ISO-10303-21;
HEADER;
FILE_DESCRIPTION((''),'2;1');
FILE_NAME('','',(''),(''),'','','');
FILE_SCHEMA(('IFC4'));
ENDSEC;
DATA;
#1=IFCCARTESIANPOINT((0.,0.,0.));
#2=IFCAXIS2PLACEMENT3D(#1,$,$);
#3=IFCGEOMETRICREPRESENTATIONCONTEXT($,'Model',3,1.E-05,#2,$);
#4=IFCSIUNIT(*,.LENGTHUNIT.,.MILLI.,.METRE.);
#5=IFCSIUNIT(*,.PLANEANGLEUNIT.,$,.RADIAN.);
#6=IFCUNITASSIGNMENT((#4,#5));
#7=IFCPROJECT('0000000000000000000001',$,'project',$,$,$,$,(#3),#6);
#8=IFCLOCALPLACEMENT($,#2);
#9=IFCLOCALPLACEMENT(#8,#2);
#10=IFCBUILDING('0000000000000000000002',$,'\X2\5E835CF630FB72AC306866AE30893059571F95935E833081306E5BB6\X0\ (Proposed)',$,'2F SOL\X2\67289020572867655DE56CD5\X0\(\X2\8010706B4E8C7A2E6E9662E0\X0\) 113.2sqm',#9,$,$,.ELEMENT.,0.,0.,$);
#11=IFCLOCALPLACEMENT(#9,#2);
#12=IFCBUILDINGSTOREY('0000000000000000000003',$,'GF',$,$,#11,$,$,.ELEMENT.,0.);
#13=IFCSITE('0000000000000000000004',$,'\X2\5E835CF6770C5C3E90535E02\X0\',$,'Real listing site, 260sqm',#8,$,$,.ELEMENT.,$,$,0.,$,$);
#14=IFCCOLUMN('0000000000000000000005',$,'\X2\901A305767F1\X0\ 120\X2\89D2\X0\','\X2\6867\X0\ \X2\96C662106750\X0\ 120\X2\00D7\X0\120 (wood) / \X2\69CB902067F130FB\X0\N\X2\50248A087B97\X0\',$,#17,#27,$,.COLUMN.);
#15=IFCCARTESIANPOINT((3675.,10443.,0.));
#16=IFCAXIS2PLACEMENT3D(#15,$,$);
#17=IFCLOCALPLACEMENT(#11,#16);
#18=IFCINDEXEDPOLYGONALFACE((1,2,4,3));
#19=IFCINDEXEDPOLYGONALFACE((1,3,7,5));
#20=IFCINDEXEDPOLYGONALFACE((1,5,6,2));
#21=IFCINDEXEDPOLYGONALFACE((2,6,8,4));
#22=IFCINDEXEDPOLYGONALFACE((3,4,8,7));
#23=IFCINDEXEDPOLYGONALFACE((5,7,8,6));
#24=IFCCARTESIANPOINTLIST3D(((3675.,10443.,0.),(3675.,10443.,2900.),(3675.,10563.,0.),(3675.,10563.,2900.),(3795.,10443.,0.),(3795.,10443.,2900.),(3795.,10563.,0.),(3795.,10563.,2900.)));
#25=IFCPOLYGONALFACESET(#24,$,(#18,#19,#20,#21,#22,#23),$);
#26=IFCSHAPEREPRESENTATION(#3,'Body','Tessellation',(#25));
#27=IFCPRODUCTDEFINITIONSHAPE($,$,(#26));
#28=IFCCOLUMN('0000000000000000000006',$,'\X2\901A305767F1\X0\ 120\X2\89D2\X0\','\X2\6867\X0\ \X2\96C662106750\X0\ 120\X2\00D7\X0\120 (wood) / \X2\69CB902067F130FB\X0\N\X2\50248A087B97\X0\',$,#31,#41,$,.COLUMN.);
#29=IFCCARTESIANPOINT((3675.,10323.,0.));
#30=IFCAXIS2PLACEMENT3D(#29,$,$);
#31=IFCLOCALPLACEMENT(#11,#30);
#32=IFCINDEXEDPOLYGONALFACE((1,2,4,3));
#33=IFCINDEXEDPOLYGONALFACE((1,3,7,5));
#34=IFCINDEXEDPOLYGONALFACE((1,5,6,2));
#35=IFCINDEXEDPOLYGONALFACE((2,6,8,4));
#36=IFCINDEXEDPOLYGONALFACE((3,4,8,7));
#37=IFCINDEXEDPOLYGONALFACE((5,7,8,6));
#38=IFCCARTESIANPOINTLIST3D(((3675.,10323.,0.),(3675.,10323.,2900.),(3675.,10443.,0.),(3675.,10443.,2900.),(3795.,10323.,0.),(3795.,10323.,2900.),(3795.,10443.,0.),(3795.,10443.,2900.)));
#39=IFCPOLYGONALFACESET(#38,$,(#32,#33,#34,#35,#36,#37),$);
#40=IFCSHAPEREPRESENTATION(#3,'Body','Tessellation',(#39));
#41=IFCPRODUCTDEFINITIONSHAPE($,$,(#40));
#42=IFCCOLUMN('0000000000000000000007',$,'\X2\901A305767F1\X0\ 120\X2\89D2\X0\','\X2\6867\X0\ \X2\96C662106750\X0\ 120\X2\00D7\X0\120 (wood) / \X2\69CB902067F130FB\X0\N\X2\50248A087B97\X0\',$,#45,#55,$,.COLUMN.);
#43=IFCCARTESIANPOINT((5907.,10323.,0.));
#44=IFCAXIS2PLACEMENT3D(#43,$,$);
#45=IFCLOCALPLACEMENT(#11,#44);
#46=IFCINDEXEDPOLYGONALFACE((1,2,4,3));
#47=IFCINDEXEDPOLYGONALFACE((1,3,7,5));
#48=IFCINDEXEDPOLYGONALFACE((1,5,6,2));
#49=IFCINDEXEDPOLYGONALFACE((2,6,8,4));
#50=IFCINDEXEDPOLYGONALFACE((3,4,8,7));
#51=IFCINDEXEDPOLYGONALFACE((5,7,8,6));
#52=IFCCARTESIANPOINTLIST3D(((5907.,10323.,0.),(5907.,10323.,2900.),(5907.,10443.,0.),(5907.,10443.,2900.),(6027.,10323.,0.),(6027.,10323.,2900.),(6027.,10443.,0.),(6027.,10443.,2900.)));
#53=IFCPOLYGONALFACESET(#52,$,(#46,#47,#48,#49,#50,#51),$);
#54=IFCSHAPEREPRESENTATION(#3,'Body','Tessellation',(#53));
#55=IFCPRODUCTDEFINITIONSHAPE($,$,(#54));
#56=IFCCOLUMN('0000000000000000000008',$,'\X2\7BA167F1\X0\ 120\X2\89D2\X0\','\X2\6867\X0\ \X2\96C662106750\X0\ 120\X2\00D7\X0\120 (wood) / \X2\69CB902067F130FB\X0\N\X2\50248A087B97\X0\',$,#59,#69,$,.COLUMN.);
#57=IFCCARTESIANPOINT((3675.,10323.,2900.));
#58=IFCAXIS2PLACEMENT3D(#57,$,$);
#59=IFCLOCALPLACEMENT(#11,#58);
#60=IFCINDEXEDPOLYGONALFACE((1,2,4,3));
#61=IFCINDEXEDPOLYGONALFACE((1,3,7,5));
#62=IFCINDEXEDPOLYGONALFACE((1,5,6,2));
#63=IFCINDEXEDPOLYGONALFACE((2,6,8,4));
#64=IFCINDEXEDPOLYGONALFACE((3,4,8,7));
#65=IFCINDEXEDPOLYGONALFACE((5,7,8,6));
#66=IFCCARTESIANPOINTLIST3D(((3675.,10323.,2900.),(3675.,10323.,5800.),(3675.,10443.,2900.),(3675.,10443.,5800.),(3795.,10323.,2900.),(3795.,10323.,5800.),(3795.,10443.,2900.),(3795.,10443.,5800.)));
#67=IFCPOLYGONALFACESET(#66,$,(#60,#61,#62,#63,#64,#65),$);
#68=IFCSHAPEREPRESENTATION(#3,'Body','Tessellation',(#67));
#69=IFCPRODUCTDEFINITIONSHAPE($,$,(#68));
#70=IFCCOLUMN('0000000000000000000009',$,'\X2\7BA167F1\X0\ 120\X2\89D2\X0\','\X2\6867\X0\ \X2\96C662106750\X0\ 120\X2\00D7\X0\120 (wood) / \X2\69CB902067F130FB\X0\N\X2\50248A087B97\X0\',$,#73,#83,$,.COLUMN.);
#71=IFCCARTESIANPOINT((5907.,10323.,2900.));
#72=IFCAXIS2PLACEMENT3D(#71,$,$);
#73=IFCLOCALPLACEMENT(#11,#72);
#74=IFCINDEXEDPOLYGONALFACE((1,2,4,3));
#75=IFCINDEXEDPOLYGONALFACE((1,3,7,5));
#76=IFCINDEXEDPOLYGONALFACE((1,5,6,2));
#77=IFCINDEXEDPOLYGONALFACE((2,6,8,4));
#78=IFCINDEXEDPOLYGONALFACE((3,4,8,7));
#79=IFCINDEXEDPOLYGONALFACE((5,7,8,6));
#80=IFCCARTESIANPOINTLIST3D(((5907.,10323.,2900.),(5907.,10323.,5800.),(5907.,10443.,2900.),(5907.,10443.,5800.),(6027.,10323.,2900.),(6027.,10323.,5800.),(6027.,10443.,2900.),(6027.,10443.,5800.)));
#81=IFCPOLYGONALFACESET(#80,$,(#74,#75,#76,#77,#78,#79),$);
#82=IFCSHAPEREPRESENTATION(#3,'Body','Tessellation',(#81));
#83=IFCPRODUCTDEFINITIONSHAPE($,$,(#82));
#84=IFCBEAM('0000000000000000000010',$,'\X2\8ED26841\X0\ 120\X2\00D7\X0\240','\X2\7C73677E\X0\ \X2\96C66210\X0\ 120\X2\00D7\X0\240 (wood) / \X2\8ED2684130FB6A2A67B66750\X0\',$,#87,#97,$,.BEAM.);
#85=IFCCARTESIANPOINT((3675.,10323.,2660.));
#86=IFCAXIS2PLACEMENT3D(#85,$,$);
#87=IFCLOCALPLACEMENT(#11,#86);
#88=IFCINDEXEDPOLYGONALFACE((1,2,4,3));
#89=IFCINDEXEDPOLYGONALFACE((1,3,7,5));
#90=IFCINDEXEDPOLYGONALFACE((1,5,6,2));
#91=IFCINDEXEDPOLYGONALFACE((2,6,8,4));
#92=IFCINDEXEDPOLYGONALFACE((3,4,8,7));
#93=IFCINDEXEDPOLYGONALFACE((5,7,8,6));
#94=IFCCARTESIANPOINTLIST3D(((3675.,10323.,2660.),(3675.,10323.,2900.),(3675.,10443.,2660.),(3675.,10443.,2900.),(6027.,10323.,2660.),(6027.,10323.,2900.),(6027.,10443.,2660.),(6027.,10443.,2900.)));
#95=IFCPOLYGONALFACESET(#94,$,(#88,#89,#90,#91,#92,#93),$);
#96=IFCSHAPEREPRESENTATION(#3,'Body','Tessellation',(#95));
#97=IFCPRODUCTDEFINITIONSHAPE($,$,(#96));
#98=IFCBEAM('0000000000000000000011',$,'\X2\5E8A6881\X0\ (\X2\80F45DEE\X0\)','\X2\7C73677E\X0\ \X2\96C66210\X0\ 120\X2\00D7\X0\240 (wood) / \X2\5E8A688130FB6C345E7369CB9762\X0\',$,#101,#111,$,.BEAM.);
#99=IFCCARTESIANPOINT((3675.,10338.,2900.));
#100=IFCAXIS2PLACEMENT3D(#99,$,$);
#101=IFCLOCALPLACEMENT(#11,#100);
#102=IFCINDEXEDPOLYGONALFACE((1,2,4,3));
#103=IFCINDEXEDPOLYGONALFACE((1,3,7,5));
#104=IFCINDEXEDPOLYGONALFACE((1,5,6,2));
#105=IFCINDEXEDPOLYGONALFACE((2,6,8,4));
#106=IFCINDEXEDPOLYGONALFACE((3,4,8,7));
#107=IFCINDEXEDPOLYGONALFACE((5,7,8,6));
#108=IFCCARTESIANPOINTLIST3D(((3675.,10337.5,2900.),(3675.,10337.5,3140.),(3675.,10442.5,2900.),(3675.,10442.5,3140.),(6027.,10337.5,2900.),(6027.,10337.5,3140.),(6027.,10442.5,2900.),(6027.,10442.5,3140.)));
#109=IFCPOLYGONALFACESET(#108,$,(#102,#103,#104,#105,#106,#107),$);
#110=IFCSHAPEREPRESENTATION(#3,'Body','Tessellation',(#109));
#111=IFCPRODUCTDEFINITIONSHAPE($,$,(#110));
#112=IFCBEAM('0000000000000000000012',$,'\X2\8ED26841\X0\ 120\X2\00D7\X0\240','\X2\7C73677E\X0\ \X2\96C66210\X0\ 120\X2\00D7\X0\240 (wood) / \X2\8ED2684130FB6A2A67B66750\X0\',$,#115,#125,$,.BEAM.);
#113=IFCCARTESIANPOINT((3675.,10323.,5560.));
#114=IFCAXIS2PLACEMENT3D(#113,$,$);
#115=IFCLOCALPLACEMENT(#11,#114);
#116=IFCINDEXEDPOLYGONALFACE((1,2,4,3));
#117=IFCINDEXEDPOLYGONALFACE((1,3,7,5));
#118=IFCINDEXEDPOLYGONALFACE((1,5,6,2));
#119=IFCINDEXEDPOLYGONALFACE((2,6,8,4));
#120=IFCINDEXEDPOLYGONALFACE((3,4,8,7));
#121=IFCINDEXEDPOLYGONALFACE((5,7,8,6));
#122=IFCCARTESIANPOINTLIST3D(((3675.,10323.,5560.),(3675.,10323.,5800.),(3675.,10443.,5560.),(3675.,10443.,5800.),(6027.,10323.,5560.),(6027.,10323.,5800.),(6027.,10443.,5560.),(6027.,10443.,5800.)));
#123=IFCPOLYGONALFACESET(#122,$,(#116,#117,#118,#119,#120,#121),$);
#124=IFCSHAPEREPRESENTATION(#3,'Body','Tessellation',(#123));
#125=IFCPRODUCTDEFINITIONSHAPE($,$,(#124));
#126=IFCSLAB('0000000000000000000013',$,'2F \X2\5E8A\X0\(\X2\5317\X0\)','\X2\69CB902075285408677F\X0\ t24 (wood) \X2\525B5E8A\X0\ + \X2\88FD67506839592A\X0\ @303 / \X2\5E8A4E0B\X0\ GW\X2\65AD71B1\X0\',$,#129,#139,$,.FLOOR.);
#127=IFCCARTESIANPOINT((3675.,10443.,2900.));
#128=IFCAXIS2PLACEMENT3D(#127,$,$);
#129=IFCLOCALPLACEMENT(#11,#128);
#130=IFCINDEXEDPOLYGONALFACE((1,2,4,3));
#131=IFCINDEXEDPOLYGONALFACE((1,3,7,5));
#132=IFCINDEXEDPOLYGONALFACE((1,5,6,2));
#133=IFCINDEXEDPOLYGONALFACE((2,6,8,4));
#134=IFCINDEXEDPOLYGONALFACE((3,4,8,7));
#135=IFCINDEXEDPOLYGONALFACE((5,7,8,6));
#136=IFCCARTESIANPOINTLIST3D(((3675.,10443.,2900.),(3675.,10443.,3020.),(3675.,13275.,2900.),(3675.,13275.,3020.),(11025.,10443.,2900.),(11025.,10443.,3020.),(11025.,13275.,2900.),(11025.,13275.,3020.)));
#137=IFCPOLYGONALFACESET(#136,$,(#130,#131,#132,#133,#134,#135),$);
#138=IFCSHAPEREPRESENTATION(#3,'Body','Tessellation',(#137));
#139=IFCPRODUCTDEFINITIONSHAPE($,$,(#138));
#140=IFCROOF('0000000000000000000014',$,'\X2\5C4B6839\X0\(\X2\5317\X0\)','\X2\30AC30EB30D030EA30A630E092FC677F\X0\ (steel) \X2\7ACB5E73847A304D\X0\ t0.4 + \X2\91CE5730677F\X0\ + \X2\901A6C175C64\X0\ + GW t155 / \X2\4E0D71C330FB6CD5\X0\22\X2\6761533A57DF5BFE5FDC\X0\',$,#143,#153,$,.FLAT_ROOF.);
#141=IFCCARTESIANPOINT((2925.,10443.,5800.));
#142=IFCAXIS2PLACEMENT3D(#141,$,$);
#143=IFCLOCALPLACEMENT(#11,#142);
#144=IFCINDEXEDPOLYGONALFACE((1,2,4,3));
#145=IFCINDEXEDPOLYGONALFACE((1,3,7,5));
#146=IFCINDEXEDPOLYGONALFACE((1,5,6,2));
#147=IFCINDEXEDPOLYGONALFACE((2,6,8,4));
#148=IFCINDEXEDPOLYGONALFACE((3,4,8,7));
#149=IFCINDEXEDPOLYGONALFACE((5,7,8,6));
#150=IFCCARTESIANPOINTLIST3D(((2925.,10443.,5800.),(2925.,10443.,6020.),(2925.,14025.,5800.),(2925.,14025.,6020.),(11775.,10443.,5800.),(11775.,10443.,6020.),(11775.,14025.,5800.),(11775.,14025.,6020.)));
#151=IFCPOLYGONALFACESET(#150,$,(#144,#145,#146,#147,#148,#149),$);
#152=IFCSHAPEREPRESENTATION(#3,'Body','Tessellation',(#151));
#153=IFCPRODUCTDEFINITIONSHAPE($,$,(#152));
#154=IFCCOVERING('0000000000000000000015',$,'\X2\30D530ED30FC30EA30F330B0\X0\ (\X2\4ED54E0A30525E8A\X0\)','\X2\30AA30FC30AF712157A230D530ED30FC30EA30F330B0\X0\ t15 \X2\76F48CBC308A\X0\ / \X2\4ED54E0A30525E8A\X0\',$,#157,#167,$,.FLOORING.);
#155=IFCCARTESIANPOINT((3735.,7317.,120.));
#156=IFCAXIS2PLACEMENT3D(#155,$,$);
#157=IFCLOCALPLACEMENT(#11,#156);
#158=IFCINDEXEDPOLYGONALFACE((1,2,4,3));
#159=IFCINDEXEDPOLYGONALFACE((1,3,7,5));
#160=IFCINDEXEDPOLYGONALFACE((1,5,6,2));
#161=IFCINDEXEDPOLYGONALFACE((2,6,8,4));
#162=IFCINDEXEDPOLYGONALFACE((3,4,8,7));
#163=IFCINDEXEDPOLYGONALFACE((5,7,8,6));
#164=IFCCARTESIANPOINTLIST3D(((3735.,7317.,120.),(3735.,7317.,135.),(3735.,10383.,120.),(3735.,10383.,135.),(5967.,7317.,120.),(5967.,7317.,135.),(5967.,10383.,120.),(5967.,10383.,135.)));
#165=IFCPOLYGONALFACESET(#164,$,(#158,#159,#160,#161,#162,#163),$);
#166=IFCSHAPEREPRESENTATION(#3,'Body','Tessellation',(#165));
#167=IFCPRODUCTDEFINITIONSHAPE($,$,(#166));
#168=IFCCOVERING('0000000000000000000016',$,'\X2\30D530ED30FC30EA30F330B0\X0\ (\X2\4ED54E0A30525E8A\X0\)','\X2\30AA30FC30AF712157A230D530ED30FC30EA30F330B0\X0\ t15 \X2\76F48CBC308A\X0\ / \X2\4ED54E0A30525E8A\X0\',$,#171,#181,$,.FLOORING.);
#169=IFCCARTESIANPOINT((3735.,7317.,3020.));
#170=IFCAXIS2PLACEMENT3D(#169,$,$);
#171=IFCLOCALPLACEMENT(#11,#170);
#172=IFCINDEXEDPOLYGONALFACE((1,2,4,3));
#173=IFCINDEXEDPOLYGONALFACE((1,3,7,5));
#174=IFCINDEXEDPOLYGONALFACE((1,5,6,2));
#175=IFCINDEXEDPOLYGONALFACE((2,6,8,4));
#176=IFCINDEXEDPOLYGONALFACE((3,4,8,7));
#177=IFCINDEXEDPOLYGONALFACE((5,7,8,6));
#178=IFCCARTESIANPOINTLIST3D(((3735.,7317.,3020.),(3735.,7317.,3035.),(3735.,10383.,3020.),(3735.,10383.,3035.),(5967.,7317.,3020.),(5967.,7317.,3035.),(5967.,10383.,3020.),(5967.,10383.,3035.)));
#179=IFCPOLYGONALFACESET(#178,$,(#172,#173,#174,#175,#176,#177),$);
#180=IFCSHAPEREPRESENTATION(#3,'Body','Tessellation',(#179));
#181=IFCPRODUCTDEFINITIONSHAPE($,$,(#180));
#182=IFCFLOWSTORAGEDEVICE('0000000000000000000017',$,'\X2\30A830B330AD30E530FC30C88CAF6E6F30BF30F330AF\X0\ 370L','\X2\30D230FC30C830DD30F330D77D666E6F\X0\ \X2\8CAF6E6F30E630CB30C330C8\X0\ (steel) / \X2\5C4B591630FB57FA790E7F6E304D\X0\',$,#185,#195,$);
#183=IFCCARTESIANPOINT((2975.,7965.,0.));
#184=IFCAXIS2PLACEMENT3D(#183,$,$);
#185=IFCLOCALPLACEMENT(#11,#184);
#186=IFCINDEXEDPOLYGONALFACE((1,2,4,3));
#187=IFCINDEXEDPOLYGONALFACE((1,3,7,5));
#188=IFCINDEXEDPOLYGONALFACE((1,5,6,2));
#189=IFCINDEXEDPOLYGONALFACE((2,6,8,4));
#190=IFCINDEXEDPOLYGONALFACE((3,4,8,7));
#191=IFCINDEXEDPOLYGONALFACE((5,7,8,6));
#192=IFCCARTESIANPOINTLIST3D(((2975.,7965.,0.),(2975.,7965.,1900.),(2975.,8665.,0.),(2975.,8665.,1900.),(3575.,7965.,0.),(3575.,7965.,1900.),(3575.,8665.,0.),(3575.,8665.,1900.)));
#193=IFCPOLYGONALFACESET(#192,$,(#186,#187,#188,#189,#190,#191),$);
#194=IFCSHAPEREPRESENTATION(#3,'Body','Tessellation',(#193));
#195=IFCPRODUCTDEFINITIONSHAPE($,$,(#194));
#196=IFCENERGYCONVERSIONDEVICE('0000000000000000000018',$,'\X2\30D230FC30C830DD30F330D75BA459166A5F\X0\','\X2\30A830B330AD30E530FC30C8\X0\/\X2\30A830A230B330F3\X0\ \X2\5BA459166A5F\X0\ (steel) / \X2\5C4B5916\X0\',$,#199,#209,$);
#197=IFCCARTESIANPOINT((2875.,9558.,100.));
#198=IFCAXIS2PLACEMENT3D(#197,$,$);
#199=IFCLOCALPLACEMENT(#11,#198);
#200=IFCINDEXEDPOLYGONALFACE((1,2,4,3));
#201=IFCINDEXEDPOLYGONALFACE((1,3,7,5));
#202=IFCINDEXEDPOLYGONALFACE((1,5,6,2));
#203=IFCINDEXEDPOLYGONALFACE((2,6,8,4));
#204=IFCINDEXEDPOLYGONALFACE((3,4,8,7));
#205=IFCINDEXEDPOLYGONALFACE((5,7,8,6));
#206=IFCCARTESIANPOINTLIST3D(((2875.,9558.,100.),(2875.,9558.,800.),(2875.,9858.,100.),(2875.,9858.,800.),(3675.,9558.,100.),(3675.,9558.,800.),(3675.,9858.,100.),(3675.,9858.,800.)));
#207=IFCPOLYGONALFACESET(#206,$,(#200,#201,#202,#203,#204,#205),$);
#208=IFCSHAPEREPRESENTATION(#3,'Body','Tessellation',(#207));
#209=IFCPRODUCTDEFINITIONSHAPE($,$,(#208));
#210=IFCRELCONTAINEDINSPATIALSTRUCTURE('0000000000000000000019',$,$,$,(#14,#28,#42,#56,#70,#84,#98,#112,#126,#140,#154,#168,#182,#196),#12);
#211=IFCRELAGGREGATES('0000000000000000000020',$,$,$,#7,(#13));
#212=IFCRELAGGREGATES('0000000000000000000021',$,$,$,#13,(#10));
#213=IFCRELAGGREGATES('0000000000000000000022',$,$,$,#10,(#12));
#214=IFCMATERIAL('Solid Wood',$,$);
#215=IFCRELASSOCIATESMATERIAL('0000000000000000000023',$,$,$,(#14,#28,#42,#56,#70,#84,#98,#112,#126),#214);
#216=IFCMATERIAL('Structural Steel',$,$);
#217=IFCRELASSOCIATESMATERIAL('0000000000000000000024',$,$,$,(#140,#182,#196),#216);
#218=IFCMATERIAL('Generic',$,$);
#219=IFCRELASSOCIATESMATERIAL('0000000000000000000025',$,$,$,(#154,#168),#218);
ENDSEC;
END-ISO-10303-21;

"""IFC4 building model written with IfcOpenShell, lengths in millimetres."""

from ifc_helpers import new_model, si_unit, frame, frame_2d, origin, place, context, project, spatial, rectangle, extrude, material, element, save


model = new_model("IFC4")

# Units and contexts
model_context = context("Model", 3, precision=1e-05, world=origin())
ifc_project = project(units=[si_unit("LENGTHUNIT", "METRE", prefix="MILLI"), si_unit("PLANEANGLEUNIT", "RADIAN")], contexts=[model_context])

# Site, building, storey
site_placement = place(None, origin())
site = spatial("IfcSite", under=ifc_project, at=site_placement, Name="広島県尾道市", ObjectType="Real listing site, 260sqm", CompositionType="ELEMENT", RefElevation=0.0)
building_placement = place(site_placement, origin())
building = spatial("IfcBuilding", under=site, at=building_placement, Name="広島・犬と暮らす土間広めの家 (Proposed)", ObjectType="2F SOL木造在来工法(耐火二種準拠) 113.2sqm", CompositionType="ELEMENT", ElevationOfRefHeight=0.0, ElevationOfTerrain=0.0)
storey_placement = place(building_placement, origin())
storey = spatial("IfcBuildingStorey", under=building, at=storey_placement, Name="GF", CompositionType="ELEMENT", Elevation=0.0)

# Columns
ifc_material_1 = material(Name="Solid Wood")
column_1_placement = place(storey_placement, frame((3675.0, 10443.0, 0.0)))
element("IfcColumn", 1, at=column_1_placement, inside=storey, material=ifc_material_1, Name="通し柱 120角", Description="桧 集成材 120×120 (wood) / 構造柱・N値計算", PredefinedType="COLUMN", context=model_context, shape_type="SweptSolid", body=[
    extrude(rectangle(XDim=120.0, YDim=120.0, at=frame_2d((60.0, 60.0))), frame((3675.0, 10443.0, 0.0)), (0.0, 0.0, 1.0), 2900.0),
])
column_2_placement = place(storey_placement, frame((3675.0, 10323.0, 0.0)))
element("IfcColumn", 2, at=column_2_placement, inside=storey, material=ifc_material_1, Name="通し柱 120角", Description="桧 集成材 120×120 (wood) / 構造柱・N値計算", PredefinedType="COLUMN", context=model_context, shape_type="SweptSolid", body=[
    extrude(rectangle(XDim=120.0, YDim=120.0, at=frame_2d((60.0, 60.0))), frame((3675.0, 10323.0, 0.0)), (0.0, 0.0, 1.0), 2900.0),
])
column_3_placement = place(storey_placement, frame((5907.0, 10323.0, 0.0)))
element("IfcColumn", 3, at=column_3_placement, inside=storey, material=ifc_material_1, Name="通し柱 120角", Description="桧 集成材 120×120 (wood) / 構造柱・N値計算", PredefinedType="COLUMN", context=model_context, shape_type="SweptSolid", body=[
    extrude(rectangle(XDim=120.0, YDim=120.0, at=frame_2d((60.0, 60.0))), frame((5907.0, 10323.0, 0.0)), (0.0, 0.0, 1.0), 2900.0),
])
column_4_placement = place(storey_placement, frame((3675.0, 10323.0, 2900.0)))
element("IfcColumn", 4, at=column_4_placement, inside=storey, material=ifc_material_1, Name="管柱 120角", Description="桧 集成材 120×120 (wood) / 構造柱・N値計算", PredefinedType="COLUMN", context=model_context, shape_type="SweptSolid", body=[
    extrude(rectangle(XDim=120.0, YDim=120.0, at=frame_2d((60.0, 60.0))), frame((3675.0, 10323.0, 2900.0)), (0.0, 0.0, 1.0), 2900.0),
])
column_5_placement = place(storey_placement, frame((5907.0, 10323.0, 2900.0)))
element("IfcColumn", 5, at=column_5_placement, inside=storey, material=ifc_material_1, Name="管柱 120角", Description="桧 集成材 120×120 (wood) / 構造柱・N値計算", PredefinedType="COLUMN", context=model_context, shape_type="SweptSolid", body=[
    extrude(rectangle(XDim=120.0, YDim=120.0, at=frame_2d((60.0, 60.0))), frame((5907.0, 10323.0, 2900.0)), (0.0, 0.0, 1.0), 2900.0),
])

# Beams
beam_1_placement = place(storey_placement, frame((3675.0, 10323.0, 2660.0)))
element("IfcBeam", 6, at=beam_1_placement, inside=storey, material=ifc_material_1, Name="軒桁 120×240", Description="米松 集成 120×240 (wood) / 軒桁・横架材", PredefinedType="BEAM", context=model_context, shape_type="SweptSolid", body=[
    extrude(rectangle(XDim=2352.0, YDim=120.0, at=frame_2d((1176.0, 60.0))), frame((3675.0, 10323.0, 2660.0)), (0.0, 0.0, 1.0), 240.0),
])
beam_2_placement = place(storey_placement, frame((3675.0, 10338.0, 2900.0)))
element("IfcBeam", 7, at=beam_2_placement, inside=storey, material=ifc_material_1, Name="床梁 (胴差)", Description="米松 集成 120×240 (wood) / 床梁・水平構面", PredefinedType="BEAM", context=model_context, shape_type="SweptSolid", body=[
    extrude(rectangle(XDim=2352.0, YDim=105.0, at=frame_2d((1176.0, 52.0))), frame((3675.0, 10338.0, 2900.0)), (0.0, 0.0, 1.0), 240.0),
])
beam_3_placement = place(storey_placement, frame((3675.0, 10323.0, 5560.0)))
element("IfcBeam", 8, at=beam_3_placement, inside=storey, material=ifc_material_1, Name="軒桁 120×240", Description="米松 集成 120×240 (wood) / 軒桁・横架材", PredefinedType="BEAM", context=model_context, shape_type="SweptSolid", body=[
    extrude(rectangle(XDim=2352.0, YDim=120.0, at=frame_2d((1176.0, 60.0))), frame((3675.0, 10323.0, 5560.0)), (0.0, 0.0, 1.0), 240.0),
])

# Slab
slab_1_placement = place(storey_placement, frame((3675.0, 10443.0, 2900.0)))
element("IfcSlab", 9, at=slab_1_placement, inside=storey, material=ifc_material_1, Name="2F 床(北)", Description="構造用合板 t24 (wood) 剛床 + 製材根太 @303 / 床下 GW断熱", PredefinedType="FLOOR", context=model_context, shape_type="SweptSolid", body=[
    extrude(rectangle(XDim=7350.0, YDim=2832.0, at=frame_2d((3675.0, 1416.0))), frame((3675.0, 10443.0, 2900.0)), (0.0, 0.0, 1.0), 120.0),
])

# Roof
ifc_material_2 = material(Name="Structural Steel")
for number, where, name in (
    (10, (2925.0, 10443.0, 5800.0), "屋根(北)"),
):
    element("IfcRoof", number, at=place(storey_placement, frame(where)), inside=storey, material=ifc_material_2, Name=name, Description="ガルバリウム鋼板 (steel) 立平葺き t0.4 + 野地板 + 通気層 + GW t155 / 不燃・法22条区域対応", PredefinedType="FLAT_ROOF", context=model_context, shape_type="SweptSolid", body=[
        extrude(rectangle(XDim=8850.0, YDim=3582.0, at=frame_2d((4425.0, 1791.0))), frame((2925.0, 10443.0, 5800.0)), (0.0, 0.0, 1.0), 220.0),
    ])

# Coverings
ifc_material_3 = material(Name="Generic")
covering_1_placement = place(storey_placement, frame((3735.0, 7317.0, 120.0)))
element("IfcCovering", 11, at=covering_1_placement, inside=storey, material=ifc_material_3, Name="フローリング (仕上げ床)", Description="オーク無垢フローリング t15 直貼り / 仕上げ床", PredefinedType="FLOORING", context=model_context, shape_type="SweptSolid", body=[
    extrude(rectangle(XDim=2232.0, YDim=3066.0, at=frame_2d((1116.0, 1533.0))), frame((3735.0, 7317.0, 120.0)), (0.0, 0.0, 1.0), 15.0),
])
covering_2_placement = place(storey_placement, frame((3735.0, 7317.0, 3020.0)))
element("IfcCovering", 12, at=covering_2_placement, inside=storey, material=ifc_material_3, Name="フローリング (仕上げ床)", Description="オーク無垢フローリング t15 直貼り / 仕上げ床", PredefinedType="FLOORING", context=model_context, shape_type="SweptSolid", body=[
    extrude(rectangle(XDim=2232.0, YDim=3066.0, at=frame_2d((1116.0, 1533.0))), frame((3735.0, 7317.0, 3020.0)), (0.0, 0.0, 1.0), 15.0),
])

# Flow storage device
flow_storage_device_placement = place(storey_placement, frame((2975.0, 7965.0, 0.0)))
element("IfcFlowStorageDevice", 13, at=flow_storage_device_placement, inside=storey, material=ifc_material_2, Name="エコキュート貯湯タンク 370L", Description="ヒートポンプ給湯 貯湯ユニット (steel) / 屋外・基礎置き", context=model_context, shape_type="SweptSolid", body=[
    extrude(rectangle(XDim=600.0, YDim=700.0, at=frame_2d((300.0, 350.0))), frame((2975.0, 7965.0, 0.0)), (0.0, 0.0, 1.0), 1900.0),
])

# Energy conversion device
energy_conversion_device_placement = place(storey_placement, frame((2875.0, 9558.0, 100.0)))
element("IfcEnergyConversionDevice", 14, at=energy_conversion_device_placement, inside=storey, material=ifc_material_2, Name="ヒートポンプ室外機", Description="エコキュート/エアコン 室外機 (steel) / 屋外", context=model_context, shape_type="SweptSolid", body=[
    extrude(rectangle(XDim=800.0, YDim=300.0, at=frame_2d((400.0, 150.0))), frame((2875.0, 9558.0, 100.0)), (0.0, 0.0, 1.0), 700.0),
])

save(model, "model.ifc")
